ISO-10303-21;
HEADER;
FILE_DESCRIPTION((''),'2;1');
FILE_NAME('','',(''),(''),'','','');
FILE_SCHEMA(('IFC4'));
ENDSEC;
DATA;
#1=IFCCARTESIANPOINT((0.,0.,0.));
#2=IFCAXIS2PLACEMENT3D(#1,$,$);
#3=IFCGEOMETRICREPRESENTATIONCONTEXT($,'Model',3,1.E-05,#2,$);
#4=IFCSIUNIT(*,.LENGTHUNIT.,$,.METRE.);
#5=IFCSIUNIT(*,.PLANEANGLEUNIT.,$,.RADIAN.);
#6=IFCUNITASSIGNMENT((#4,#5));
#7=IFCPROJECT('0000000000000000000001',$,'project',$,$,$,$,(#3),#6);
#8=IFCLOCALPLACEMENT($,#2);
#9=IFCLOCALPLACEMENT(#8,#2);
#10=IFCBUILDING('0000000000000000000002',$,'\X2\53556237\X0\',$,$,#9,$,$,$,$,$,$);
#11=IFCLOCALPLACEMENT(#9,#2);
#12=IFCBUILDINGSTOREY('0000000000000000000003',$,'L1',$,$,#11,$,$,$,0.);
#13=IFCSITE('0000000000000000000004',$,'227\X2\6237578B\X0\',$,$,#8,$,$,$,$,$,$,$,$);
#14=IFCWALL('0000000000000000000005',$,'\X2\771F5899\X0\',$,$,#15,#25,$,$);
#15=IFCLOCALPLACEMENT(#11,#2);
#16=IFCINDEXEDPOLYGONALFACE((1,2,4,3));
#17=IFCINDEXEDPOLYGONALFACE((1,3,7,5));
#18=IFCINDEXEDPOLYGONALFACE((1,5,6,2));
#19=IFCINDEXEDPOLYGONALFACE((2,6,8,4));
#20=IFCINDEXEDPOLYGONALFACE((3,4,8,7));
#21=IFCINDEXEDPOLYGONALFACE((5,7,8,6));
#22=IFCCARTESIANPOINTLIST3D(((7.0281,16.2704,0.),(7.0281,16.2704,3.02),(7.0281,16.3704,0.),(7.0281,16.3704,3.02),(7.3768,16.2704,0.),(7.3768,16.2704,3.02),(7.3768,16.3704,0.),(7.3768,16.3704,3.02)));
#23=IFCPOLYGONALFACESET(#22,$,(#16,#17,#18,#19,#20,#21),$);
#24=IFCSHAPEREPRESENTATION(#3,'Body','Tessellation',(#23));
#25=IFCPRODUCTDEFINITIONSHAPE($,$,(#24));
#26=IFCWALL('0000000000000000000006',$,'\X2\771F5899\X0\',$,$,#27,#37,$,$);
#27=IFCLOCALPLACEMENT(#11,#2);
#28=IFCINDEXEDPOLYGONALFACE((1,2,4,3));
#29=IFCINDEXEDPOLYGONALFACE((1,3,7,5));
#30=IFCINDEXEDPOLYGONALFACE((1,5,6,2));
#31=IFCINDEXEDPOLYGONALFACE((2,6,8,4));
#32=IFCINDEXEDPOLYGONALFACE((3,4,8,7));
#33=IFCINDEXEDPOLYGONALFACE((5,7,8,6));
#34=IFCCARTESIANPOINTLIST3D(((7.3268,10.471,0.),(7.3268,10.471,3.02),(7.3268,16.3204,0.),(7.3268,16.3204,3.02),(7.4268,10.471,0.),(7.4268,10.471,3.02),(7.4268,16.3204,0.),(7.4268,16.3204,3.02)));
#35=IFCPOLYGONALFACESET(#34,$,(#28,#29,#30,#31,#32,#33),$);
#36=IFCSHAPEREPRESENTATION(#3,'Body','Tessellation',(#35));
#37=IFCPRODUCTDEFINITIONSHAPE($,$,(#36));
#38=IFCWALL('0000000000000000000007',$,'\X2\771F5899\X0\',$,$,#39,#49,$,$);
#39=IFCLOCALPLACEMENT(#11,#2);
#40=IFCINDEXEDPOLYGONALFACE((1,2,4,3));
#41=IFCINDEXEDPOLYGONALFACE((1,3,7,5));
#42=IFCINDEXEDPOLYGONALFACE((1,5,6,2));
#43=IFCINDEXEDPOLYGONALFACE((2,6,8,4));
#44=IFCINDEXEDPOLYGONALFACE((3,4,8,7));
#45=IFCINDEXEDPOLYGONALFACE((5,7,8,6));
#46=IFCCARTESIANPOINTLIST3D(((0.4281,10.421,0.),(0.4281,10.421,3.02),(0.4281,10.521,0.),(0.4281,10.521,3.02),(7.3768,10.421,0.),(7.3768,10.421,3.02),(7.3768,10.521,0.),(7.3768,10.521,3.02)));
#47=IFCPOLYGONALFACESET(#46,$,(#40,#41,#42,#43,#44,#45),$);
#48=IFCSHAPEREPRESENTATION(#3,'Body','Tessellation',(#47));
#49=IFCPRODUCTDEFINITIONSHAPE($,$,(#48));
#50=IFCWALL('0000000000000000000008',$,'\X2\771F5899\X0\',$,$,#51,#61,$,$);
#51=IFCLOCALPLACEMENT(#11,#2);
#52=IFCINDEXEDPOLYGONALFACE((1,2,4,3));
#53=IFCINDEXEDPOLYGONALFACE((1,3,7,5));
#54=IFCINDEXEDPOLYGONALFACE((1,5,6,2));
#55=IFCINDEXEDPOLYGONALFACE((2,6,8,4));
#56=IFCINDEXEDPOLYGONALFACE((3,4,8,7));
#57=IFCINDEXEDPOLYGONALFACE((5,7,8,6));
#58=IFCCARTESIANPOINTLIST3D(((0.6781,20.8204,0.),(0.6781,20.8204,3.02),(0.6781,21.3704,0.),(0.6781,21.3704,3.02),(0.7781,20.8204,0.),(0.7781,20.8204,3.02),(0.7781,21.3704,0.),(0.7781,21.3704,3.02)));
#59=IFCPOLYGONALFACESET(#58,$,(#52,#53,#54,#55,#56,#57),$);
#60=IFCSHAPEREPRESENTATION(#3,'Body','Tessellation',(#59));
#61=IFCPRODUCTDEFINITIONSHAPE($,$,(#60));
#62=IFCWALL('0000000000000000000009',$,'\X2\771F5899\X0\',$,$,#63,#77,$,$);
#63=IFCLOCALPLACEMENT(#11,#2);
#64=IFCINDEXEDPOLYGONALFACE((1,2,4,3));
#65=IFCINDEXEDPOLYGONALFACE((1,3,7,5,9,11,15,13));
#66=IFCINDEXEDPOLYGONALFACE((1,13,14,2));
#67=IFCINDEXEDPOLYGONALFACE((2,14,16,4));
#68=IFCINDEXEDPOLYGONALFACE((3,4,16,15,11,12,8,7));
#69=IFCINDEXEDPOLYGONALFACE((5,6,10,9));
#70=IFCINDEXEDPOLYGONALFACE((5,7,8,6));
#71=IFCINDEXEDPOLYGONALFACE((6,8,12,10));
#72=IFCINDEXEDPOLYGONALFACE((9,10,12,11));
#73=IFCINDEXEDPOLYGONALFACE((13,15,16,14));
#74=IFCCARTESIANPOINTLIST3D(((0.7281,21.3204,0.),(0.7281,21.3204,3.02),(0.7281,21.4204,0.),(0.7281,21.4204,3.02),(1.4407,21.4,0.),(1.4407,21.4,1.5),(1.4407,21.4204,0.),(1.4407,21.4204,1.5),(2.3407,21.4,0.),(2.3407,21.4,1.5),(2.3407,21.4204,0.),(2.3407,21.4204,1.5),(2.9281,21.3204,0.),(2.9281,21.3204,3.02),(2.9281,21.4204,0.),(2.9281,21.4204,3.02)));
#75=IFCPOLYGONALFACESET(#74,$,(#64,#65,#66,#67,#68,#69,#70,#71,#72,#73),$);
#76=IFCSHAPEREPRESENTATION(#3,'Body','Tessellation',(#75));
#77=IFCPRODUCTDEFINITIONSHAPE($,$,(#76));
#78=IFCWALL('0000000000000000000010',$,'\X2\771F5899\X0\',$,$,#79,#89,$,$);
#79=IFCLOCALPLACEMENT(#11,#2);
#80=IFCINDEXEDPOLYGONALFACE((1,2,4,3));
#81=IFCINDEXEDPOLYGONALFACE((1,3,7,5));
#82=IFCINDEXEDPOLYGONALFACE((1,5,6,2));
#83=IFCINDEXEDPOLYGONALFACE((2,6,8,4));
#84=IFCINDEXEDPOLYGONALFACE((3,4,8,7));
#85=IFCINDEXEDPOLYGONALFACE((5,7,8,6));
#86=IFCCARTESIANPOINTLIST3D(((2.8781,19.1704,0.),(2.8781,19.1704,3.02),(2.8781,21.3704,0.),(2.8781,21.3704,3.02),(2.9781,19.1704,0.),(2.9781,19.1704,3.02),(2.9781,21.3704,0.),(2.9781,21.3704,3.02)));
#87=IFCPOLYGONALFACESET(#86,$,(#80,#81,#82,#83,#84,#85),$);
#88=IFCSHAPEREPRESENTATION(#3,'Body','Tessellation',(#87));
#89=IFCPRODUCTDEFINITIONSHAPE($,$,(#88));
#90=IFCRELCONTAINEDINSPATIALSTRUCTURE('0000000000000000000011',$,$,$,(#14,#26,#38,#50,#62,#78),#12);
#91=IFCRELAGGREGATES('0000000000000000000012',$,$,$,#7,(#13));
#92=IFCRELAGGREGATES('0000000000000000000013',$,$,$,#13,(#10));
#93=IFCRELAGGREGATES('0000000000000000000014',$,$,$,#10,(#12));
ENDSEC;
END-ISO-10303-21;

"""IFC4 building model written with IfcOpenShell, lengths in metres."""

from ifc_helpers import new_model, si_unit, origin, place, context, project, spatial, polyline, outline, extrude, element, save


model = new_model("IFC4")

# Units and contexts
model_context = context("Model", 3, precision=1e-05, world=origin())
ifc_project = project(units=[si_unit("LENGTHUNIT", "METRE"), si_unit("PLANEANGLEUNIT", "RADIAN")], contexts=[model_context])

# Site, building, storey
site_placement = place(None, origin())
site = spatial("IfcSite", under=ifc_project, at=site_placement, Name="227户型")
building_placement = place(site_placement, origin())
building = spatial("IfcBuilding", under=site, at=building_placement, Name="单户")
storey_placement = place(building_placement, origin())
storey = spatial("IfcBuildingStorey", under=building, at=storey_placement, Name="L1", Elevation=0.0)

# Walls
wall_1_placement = place(storey_placement, origin())
element("IfcWall", 1, at=wall_1_placement, inside=storey, Name="真墙", context=model_context, shape_type="SweptSolid", body=[
    extrude(outline(polyline([(7.0281, 16.3704), (7.3768, 16.3704), (7.3768, 16.2704), (7.0281, 16.2704), (7.0281, 16.3704)])), origin(), (0.0, 0.0, 1.0), 3.02),
])
wall_2_placement = place(storey_placement, origin())
element("IfcWall", 2, at=wall_2_placement, inside=storey, Name="真墙", context=model_context, shape_type="SweptSolid", body=[
    extrude(outline(polyline([(7.4268, 16.3204), (7.4268, 10.471), (7.3268, 10.471), (7.3268, 16.3204), (7.4268, 16.3204)])), origin(), (0.0, 0.0, 1.0), 3.02),
])
wall_3_placement = place(storey_placement, origin())
element("IfcWall", 3, at=wall_3_placement, inside=storey, Name="真墙", context=model_context, shape_type="SweptSolid", body=[
    extrude(outline(polyline([(7.3768, 10.421), (0.4281, 10.421), (0.4281, 10.521), (7.3768, 10.521), (7.3768, 10.421)])), origin(), (0.0, 0.0, 1.0), 3.02),
])
wall_4_placement = place(storey_placement, origin())
element("IfcWall", 4, at=wall_4_placement, inside=storey, Name="真墙", context=model_context, shape_type="SweptSolid", body=[
    extrude(outline(polyline([(0.6781, 20.8204), (0.6781, 21.3704), (0.7781, 21.3704), (0.7781, 20.8204), (0.6781, 20.8204)])), origin(), (0.0, 0.0, 1.0), 3.02),
])

# Wall, opening
wall_5_placement = place(storey_placement, origin())
wall_5 = element("IfcWall", 5, at=wall_5_placement, inside=storey, Name="真墙", context=model_context, shape_type="SweptSolid", body=[
    extrude(outline(polyline([(0.7281, 21.4204), (2.9281, 21.4204), (2.9281, 21.3204), (0.7281, 21.3204), (0.7281, 21.4204)])), origin(), (0.0, 0.0, 1.0), 3.02),
])
opening_1_placement = place(storey_placement, origin())
element("IfcOpeningElement", 6, at=opening_1_placement, cuts=wall_5, context=model_context, shape_type="SweptSolid", body=[
    extrude(outline(polyline([(1.4407, 21.6), (2.3407, 21.6), (2.3407, 21.4), (1.4407, 21.4), (1.4407, 21.6)])), origin(), (0.0, 0.0, 1.0), 1.5),
])

# Wall
wall_6_placement = place(storey_placement, origin())
element("IfcWall", 7, at=wall_6_placement, inside=storey, Name="真墙", context=model_context, shape_type="SweptSolid", body=[
    extrude(outline(polyline([(2.9781, 21.3704), (2.9781, 19.1704), (2.8781, 19.1704), (2.8781, 21.3704), (2.9781, 21.3704)])), origin(), (0.0, 0.0, 1.0), 3.02),
])

save(model, "model.ifc")
